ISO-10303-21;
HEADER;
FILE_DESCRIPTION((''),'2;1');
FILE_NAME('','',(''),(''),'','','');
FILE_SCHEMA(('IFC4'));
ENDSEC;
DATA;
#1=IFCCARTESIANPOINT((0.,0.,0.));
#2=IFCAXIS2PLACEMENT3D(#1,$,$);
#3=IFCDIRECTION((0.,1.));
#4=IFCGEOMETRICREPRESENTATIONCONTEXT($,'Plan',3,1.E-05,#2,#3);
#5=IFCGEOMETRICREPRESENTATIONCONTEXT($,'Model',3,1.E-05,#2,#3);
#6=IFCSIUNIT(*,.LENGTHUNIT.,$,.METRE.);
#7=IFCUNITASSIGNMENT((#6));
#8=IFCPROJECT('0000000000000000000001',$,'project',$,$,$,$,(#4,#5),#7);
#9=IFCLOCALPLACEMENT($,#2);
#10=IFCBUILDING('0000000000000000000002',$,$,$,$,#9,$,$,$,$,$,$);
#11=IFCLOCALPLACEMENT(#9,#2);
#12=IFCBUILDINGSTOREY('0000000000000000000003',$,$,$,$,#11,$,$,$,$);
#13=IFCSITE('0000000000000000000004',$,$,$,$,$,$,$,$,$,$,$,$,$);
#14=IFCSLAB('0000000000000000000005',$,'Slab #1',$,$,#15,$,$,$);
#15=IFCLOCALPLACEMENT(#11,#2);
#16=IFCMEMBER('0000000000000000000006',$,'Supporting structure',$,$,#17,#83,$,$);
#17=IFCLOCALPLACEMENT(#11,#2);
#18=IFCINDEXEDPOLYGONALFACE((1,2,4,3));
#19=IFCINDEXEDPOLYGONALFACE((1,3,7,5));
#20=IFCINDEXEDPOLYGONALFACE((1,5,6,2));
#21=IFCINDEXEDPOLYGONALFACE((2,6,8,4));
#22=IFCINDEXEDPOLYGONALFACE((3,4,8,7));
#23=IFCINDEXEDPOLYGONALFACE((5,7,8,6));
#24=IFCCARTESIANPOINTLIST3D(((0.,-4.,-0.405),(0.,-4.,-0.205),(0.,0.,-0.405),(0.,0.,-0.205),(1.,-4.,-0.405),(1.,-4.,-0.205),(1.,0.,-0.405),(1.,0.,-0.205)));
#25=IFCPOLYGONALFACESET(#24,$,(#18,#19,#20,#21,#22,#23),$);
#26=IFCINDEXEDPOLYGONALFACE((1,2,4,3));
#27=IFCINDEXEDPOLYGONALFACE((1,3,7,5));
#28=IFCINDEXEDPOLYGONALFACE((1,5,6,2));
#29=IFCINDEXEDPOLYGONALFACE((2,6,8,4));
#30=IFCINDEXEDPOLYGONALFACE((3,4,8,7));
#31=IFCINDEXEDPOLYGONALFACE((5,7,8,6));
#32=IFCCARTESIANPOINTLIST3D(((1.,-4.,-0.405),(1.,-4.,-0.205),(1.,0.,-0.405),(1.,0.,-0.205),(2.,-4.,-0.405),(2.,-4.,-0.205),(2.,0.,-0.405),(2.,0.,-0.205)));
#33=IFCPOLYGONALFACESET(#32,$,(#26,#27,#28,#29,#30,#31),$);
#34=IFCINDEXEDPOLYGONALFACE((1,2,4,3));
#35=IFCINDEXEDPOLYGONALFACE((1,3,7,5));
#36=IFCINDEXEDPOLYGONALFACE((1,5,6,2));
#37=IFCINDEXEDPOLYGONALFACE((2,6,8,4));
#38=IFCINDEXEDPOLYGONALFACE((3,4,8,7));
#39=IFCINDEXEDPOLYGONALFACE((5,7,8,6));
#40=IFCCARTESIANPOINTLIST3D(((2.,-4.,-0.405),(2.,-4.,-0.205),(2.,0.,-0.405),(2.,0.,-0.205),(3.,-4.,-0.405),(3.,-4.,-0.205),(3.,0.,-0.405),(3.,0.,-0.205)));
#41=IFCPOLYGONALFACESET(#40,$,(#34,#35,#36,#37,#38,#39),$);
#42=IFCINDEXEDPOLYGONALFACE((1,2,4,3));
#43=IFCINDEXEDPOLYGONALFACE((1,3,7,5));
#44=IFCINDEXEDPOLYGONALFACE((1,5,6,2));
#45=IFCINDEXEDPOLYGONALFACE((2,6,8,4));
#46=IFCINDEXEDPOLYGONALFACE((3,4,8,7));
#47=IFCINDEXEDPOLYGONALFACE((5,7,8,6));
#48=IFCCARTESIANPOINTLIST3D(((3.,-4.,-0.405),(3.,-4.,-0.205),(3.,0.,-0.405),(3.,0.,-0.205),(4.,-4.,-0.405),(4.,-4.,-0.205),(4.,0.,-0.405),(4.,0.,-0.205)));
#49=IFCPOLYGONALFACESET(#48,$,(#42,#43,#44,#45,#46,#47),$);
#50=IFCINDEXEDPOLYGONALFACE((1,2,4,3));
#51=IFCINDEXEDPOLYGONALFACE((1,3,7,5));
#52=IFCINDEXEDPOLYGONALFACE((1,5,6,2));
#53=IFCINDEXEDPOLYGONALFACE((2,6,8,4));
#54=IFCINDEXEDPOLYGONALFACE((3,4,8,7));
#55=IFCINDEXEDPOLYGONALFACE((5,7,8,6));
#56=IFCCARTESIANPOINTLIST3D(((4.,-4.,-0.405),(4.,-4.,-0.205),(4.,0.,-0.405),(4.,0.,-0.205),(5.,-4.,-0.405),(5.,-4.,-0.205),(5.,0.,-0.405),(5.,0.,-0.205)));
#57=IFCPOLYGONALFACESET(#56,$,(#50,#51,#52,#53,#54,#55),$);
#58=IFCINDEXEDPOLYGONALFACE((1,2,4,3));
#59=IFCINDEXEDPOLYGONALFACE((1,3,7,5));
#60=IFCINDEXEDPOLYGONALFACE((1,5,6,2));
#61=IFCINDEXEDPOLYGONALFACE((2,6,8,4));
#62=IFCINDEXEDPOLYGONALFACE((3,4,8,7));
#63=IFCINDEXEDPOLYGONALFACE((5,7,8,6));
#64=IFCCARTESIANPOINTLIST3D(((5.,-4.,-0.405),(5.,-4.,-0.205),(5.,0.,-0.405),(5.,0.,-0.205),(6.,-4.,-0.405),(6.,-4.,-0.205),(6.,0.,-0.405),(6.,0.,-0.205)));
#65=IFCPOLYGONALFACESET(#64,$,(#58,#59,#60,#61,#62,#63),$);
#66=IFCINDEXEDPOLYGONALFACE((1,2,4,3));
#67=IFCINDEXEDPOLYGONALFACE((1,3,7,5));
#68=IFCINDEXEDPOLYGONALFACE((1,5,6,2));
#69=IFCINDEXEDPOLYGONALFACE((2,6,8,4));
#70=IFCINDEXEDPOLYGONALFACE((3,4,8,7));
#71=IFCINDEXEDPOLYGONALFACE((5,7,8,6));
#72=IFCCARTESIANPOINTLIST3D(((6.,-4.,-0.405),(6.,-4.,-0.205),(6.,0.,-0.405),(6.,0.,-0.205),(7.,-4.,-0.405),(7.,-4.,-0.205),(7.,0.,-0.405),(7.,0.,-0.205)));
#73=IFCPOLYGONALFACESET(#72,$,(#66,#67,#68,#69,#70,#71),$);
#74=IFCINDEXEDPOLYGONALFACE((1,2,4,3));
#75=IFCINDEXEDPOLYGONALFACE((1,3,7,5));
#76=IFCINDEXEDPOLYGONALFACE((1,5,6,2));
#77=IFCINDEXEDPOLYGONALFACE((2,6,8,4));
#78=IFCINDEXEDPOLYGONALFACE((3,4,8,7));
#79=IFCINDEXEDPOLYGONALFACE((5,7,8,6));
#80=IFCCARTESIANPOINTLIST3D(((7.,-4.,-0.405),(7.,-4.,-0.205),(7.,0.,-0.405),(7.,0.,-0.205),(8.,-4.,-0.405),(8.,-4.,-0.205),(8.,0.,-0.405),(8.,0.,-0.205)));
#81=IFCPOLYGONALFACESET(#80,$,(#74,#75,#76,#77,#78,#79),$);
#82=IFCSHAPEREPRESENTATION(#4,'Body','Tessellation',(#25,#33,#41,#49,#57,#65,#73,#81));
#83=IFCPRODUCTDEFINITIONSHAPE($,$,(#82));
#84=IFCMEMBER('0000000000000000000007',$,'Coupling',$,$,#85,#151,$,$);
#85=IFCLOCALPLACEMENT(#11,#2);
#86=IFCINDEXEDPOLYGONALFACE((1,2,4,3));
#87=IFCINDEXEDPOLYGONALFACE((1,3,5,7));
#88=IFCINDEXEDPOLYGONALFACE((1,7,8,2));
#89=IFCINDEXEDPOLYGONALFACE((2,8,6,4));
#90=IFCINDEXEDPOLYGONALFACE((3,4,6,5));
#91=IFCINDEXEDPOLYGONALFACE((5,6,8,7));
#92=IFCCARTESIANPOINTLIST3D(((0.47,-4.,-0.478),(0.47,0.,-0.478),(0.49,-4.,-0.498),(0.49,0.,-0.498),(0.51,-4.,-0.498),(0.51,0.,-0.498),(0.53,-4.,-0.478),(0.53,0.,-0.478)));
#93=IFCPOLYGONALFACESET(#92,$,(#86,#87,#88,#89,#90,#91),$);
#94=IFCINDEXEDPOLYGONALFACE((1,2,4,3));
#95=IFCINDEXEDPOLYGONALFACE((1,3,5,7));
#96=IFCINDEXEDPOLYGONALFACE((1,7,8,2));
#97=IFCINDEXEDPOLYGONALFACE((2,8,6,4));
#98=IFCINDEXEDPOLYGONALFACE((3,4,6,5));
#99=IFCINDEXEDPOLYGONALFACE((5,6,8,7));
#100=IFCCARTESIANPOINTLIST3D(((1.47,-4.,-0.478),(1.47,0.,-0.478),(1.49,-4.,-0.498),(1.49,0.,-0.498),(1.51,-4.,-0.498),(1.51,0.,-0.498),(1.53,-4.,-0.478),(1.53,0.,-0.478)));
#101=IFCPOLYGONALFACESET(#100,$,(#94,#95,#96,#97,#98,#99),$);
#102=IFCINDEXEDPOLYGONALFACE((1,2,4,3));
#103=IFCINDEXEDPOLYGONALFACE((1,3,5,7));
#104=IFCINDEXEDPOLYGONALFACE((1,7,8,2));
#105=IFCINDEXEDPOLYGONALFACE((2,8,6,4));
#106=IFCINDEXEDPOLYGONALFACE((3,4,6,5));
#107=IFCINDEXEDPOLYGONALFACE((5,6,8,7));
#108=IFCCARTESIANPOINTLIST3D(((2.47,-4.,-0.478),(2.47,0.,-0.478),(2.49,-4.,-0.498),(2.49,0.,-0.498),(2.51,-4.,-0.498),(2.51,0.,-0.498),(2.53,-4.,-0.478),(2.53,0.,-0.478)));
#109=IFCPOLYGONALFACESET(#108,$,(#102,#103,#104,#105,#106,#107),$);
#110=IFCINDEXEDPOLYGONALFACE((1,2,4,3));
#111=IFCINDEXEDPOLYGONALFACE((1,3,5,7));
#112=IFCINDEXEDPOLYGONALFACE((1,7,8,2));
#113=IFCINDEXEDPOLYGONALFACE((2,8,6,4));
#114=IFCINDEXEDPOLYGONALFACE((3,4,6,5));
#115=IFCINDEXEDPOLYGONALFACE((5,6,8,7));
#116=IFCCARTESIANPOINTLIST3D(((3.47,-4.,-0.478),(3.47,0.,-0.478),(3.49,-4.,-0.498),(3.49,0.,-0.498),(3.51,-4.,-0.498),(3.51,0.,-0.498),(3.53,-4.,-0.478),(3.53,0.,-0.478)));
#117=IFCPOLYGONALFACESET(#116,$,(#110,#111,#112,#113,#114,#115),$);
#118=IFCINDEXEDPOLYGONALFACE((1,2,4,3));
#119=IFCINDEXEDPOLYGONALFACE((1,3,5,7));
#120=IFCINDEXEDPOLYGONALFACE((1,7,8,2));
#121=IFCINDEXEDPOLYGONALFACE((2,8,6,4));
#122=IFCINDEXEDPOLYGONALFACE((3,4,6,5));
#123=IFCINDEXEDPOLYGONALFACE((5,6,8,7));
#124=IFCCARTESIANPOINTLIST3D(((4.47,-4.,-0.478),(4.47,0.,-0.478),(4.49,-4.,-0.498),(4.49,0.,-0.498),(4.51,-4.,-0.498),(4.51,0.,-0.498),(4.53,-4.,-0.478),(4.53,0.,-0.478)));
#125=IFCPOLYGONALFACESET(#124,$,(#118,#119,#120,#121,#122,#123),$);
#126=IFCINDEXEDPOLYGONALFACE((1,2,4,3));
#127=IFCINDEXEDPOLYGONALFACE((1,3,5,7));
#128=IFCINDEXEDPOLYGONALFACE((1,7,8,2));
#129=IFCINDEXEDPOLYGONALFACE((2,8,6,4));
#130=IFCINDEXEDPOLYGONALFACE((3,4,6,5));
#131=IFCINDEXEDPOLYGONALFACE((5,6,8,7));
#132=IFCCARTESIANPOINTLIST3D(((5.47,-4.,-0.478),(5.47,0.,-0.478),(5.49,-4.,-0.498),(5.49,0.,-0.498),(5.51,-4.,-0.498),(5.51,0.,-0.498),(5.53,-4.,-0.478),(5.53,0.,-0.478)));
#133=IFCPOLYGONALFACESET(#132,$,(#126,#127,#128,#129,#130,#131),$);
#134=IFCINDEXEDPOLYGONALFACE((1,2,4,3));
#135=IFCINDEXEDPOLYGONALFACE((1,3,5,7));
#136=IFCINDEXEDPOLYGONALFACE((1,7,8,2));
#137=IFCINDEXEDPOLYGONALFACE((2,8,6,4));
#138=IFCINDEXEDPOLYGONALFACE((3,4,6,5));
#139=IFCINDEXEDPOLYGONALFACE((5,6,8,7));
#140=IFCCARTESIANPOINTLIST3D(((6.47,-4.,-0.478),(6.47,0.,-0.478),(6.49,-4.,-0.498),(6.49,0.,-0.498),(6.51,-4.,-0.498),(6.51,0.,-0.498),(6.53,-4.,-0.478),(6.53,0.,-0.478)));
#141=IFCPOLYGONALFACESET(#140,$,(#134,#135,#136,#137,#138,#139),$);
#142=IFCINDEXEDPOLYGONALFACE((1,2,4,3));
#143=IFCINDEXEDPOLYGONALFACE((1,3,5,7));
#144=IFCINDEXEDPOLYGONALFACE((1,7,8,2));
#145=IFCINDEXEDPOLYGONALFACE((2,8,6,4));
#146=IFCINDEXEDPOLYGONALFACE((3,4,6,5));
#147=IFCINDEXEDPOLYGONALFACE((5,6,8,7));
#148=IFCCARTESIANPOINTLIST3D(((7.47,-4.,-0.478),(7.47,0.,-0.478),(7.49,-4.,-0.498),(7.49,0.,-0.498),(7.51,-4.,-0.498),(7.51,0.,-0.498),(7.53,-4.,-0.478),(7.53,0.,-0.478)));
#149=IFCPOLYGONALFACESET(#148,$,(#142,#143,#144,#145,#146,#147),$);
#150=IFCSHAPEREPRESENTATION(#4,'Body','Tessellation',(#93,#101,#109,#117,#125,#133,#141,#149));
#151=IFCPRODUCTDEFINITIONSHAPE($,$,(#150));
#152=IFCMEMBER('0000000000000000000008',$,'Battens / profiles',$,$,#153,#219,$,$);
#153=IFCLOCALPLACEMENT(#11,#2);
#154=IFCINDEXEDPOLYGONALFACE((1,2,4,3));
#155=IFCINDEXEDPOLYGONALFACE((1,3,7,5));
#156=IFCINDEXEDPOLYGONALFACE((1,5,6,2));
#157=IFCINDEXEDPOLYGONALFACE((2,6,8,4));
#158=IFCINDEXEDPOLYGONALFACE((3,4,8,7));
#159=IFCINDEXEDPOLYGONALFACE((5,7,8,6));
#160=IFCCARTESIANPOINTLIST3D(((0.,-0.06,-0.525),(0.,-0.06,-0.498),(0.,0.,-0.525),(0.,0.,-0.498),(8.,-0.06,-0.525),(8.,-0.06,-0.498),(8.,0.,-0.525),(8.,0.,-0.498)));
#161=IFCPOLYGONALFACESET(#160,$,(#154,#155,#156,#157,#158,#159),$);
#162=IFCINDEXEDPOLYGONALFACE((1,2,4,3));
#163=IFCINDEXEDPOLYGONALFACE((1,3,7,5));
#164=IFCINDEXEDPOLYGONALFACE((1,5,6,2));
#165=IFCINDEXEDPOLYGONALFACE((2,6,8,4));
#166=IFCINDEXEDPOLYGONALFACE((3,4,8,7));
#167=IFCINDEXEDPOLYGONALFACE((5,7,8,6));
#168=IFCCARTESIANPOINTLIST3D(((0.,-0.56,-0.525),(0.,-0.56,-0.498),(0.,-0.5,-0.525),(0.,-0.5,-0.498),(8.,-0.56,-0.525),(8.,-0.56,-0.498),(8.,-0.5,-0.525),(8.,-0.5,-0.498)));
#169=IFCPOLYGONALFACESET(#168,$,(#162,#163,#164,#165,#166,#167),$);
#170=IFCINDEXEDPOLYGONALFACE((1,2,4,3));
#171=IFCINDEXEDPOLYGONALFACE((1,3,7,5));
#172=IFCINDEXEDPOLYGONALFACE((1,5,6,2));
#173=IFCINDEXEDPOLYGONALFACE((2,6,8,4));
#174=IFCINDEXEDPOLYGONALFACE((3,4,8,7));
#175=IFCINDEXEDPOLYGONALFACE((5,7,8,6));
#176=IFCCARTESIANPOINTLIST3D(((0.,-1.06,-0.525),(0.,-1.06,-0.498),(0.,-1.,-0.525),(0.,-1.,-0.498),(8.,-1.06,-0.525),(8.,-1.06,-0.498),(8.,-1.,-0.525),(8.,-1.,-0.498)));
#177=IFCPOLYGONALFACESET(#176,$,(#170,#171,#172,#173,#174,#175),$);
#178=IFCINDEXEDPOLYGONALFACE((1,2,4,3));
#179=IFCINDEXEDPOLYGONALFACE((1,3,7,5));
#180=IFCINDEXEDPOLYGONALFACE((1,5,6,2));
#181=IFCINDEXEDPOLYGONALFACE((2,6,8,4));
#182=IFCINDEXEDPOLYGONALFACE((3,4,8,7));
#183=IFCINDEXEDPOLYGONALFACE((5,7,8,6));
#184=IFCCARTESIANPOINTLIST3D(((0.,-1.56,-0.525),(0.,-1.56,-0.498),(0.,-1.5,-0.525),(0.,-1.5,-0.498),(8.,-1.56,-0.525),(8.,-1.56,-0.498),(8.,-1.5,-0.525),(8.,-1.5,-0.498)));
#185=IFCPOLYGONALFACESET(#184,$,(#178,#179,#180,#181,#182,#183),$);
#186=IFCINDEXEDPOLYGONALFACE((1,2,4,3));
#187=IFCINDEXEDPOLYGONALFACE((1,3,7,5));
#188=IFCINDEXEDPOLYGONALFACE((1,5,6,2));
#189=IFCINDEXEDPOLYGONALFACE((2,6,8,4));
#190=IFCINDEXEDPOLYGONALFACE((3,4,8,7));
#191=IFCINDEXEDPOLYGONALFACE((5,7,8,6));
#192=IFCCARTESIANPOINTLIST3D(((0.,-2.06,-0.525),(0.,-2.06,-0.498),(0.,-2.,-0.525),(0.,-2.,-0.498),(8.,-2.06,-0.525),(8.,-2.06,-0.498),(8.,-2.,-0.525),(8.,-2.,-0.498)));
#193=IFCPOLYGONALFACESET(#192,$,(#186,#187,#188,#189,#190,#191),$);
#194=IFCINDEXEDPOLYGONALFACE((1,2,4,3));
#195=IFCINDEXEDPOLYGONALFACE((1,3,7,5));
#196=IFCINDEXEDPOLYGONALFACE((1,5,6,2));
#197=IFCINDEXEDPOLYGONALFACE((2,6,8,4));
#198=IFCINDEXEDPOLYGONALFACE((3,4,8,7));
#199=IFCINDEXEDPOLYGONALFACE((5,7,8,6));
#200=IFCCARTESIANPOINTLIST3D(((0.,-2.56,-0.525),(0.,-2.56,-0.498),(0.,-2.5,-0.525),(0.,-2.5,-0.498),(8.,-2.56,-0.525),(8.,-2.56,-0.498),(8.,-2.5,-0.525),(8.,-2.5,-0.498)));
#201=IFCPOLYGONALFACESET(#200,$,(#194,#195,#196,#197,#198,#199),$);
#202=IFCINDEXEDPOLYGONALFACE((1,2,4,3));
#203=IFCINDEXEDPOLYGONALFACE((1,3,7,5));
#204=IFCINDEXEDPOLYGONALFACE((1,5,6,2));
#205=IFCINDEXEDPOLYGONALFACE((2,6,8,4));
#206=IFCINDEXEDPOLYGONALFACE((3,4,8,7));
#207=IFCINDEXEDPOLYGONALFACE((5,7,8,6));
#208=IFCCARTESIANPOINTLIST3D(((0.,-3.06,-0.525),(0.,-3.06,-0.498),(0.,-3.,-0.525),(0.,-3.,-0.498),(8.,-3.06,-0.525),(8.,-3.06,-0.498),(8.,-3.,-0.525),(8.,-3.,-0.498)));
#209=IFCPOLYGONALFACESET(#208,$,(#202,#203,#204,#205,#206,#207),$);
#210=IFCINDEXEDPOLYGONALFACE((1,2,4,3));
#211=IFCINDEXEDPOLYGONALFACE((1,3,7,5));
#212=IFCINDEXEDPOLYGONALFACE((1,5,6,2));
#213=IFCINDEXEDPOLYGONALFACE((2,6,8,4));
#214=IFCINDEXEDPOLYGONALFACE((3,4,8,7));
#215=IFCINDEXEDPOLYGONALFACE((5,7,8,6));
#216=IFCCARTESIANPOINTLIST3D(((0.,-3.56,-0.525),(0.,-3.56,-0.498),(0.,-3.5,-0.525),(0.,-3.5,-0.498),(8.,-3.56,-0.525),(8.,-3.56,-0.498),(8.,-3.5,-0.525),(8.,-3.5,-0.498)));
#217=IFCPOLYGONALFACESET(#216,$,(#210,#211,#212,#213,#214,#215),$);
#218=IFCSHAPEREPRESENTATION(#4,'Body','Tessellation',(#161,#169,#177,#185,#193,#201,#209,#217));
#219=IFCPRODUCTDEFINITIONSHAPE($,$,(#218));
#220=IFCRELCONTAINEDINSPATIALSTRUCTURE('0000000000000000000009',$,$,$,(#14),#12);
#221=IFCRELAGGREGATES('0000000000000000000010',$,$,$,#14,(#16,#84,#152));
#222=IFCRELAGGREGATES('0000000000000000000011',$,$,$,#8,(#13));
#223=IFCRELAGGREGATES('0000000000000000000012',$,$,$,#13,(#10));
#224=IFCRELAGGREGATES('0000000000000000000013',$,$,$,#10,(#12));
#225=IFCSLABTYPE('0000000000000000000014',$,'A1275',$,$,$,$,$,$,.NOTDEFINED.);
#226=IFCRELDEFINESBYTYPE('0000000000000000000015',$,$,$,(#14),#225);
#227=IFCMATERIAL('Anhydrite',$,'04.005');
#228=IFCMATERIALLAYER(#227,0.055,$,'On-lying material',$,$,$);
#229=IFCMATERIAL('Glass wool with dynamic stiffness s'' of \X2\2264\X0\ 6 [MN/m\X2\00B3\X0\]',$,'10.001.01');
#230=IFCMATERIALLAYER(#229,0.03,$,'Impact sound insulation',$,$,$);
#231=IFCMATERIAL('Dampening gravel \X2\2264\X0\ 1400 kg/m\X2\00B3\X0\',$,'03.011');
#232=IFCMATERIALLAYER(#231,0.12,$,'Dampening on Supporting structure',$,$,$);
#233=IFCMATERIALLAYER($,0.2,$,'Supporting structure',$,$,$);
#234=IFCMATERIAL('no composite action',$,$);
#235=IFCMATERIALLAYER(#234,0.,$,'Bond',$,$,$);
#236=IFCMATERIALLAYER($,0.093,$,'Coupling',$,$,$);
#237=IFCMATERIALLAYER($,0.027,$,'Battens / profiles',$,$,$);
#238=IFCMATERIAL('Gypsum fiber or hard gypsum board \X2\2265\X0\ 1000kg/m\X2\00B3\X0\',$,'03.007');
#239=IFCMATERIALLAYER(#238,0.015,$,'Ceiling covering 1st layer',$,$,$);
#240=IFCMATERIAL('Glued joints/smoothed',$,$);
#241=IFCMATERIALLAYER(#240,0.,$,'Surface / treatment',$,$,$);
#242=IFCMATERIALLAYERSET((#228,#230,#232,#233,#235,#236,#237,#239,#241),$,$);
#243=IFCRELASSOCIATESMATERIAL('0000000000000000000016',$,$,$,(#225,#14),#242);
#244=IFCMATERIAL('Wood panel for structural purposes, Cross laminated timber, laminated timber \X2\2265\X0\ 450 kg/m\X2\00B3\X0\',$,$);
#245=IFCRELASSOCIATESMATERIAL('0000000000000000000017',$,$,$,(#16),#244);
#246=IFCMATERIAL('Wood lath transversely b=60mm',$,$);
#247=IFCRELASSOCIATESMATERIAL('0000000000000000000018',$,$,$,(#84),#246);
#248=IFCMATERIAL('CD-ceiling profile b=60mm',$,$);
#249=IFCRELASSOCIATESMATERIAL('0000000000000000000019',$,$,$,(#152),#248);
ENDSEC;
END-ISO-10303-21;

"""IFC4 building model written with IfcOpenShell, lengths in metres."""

from ifc_helpers import new_model, si_unit, direction, frame, frame_2d, origin, place, context, project, spatial, polyline, rectangle, outline, extrude, material, layer, layer_set, type_object, element, aggregate, save


model = new_model("IFC4")

# Units and contexts
plan_context = context("Plan", 3, precision=1e-05, world=origin(), true_north=direction((0.0, 1.0)))
model_context = context("Model", 3, precision=1e-05, world=origin(), true_north=direction((0.0, 1.0)))
ifc_project = project(units=[si_unit("LENGTHUNIT", "METRE")], contexts=[plan_context, model_context])

# Site, building, storey
site = spatial("IfcSite", under=ifc_project)
building_placement = place(None, origin())
building = spatial("IfcBuilding", under=site, at=building_placement)
storey_placement = place(building_placement, origin())
storey = spatial("IfcBuildingStorey", under=building, at=storey_placement)

# Slab, members
ifc_material_1 = material(Name="Anhydrite", Category="04.005")
ifc_layer_1 = layer(ifc_material_1, 0.055, Name="On-lying material")
ifc_material_2 = material(Name="Glass wool with dynamic stiffness s' of ≤ 6 [MN/m³]", Category="10.001.01")
ifc_layer_2 = layer(ifc_material_2, 0.03, Name="Impact sound insulation")
ifc_material_3 = material(Name="Dampening gravel ≤ 1400 kg/m³", Category="03.011")
ifc_layer_3 = layer(ifc_material_3, 0.12, Name="Dampening on Supporting structure")
ifc_layer_4 = layer(None, 0.2, Name="Supporting structure")
ifc_material_4 = material(Name="no composite action")
ifc_layer_5 = layer(ifc_material_4, 0.0, Name="Bond")
ifc_layer_6 = layer(None, 0.093, Name="Coupling")
ifc_layer_7 = layer(None, 0.027, Name="Battens / profiles")
ifc_material_5 = material(Name="Gypsum fiber or hard gypsum board ≥ 1000kg/m³", Category="03.007")
ifc_layer_8 = layer(ifc_material_5, 0.015, Name="Ceiling covering 1st layer")
ifc_material_6 = material(Name="Glued joints/smoothed")
ifc_layer_9 = layer(ifc_material_6, 0.0, Name="Surface / treatment")
ifc_layer_set = layer_set([ifc_layer_1, ifc_layer_2, ifc_layer_3, ifc_layer_4, ifc_layer_5, ifc_layer_6, ifc_layer_7, ifc_layer_8, ifc_layer_9])
slab_type = type_object("IfcSlabType", Name="A1275", PredefinedType="NOTDEFINED", material=ifc_layer_set)
slab_placement = place(None, frame((0.0, 0.0, 0.0), z_axis=(0.0, 0.0, -1.0), x_axis=(1.0, 0.0, 0.0)))
slab = element("IfcSlab", 1, at=slab_placement, inside=storey, type_object=slab_type, material=ifc_layer_set, Name="Slab #1")
ifc_material_7 = material(Name="Wood panel for structural purposes, Cross laminated timber, laminated timber ≥ 450 kg/m³")
member_1_placement = place(slab_placement, origin())
member_1 = element("IfcMember", 2, at=member_1_placement, material=ifc_material_7, Name="Supporting structure", context=plan_context, shape_type="SweptSolid", body=[
    extrude(rectangle(XDim=1.0, YDim=0.2, at=frame_2d((0.5, 0.1), x_axis=(1.0, 0.0))), frame((0.0, 4.0, 0.205), z_axis=(0.0, -1.0, 0.0), x_axis=(1.0, 0.0, 0.0)), (0.0, 0.0, 1.0), 4.0),
    extrude(rectangle(XDim=1.0, YDim=0.2, at=frame_2d((0.5, 0.1), x_axis=(1.0, 0.0))), frame((1.0, 4.0, 0.205), z_axis=(0.0, -1.0, 0.0), x_axis=(1.0, 0.0, 0.0)), (0.0, 0.0, 1.0), 4.0),
    extrude(rectangle(XDim=1.0, YDim=0.2, at=frame_2d((0.5, 0.1), x_axis=(1.0, 0.0))), frame((2.0, 4.0, 0.205), z_axis=(0.0, -1.0, 0.0), x_axis=(1.0, 0.0, 0.0)), (0.0, 0.0, 1.0), 4.0),
    extrude(rectangle(XDim=1.0, YDim=0.2, at=frame_2d((0.5, 0.1), x_axis=(1.0, 0.0))), frame((3.0, 4.0, 0.205), z_axis=(0.0, -1.0, 0.0), x_axis=(1.0, 0.0, 0.0)), (0.0, 0.0, 1.0), 4.0),
    extrude(rectangle(XDim=1.0, YDim=0.2, at=frame_2d((0.5, 0.1), x_axis=(1.0, 0.0))), frame((4.0, 4.0, 0.205), z_axis=(0.0, -1.0, 0.0), x_axis=(1.0, 0.0, 0.0)), (0.0, 0.0, 1.0), 4.0),
    extrude(rectangle(XDim=1.0, YDim=0.2, at=frame_2d((0.5, 0.1), x_axis=(1.0, 0.0))), frame((5.0, 4.0, 0.205), z_axis=(0.0, -1.0, 0.0), x_axis=(1.0, 0.0, 0.0)), (0.0, 0.0, 1.0), 4.0),
    extrude(rectangle(XDim=1.0, YDim=0.2, at=frame_2d((0.5, 0.1), x_axis=(1.0, 0.0))), frame((6.0, 4.0, 0.205), z_axis=(0.0, -1.0, 0.0), x_axis=(1.0, 0.0, 0.0)), (0.0, 0.0, 1.0), 4.0),
    extrude(rectangle(XDim=1.0, YDim=0.2, at=frame_2d((0.5, 0.1), x_axis=(1.0, 0.0))), frame((7.0, 4.0, 0.205), z_axis=(0.0, -1.0, 0.0), x_axis=(1.0, 0.0, 0.0)), (0.0, 0.0, 1.0), 4.0),
])
ifc_material_8 = material(Name="Wood lath transversely b=60mm")
member_2_placement = place(slab_placement, origin())
member_2 = element("IfcMember", 3, at=member_2_placement, material=ifc_material_8, Name="Coupling", context=plan_context, shape_type="SweptSolid", body=[
    extrude(outline(polyline([(0.0, 0.0), (0.06, 0.0), (0.04, 0.02), (0.02, 0.02), (0.0, 0.0)])), frame((0.47, 4.0, 0.478), z_axis=(0.0, -1.0, 0.0), x_axis=(1.0, 0.0, 0.0)), (0.0, 0.0, 1.0), 4.0),
    extrude(outline(polyline([(0.0, 0.0), (0.06, 0.0), (0.04, 0.02), (0.02, 0.02), (0.0, 0.0)])), frame((1.47, 4.0, 0.478), z_axis=(0.0, -1.0, 0.0), x_axis=(1.0, 0.0, 0.0)), (0.0, 0.0, 1.0), 4.0),
    extrude(outline(polyline([(0.0, 0.0), (0.06, 0.0), (0.04, 0.02), (0.02, 0.02), (0.0, 0.0)])), frame((2.47, 4.0, 0.478), z_axis=(0.0, -1.0, 0.0), x_axis=(1.0, 0.0, 0.0)), (0.0, 0.0, 1.0), 4.0),
    extrude(outline(polyline([(0.0, 0.0), (0.06, 0.0), (0.04, 0.02), (0.02, 0.02), (0.0, 0.0)])), frame((3.47, 4.0, 0.478), z_axis=(0.0, -1.0, 0.0), x_axis=(1.0, 0.0, 0.0)), (0.0, 0.0, 1.0), 4.0),
    extrude(outline(polyline([(0.0, 0.0), (0.06, 0.0), (0.04, 0.02), (0.02, 0.02), (0.0, 0.0)])), frame((4.47, 4.0, 0.478), z_axis=(0.0, -1.0, 0.0), x_axis=(1.0, 0.0, 0.0)), (0.0, 0.0, 1.0), 4.0),
    extrude(outline(polyline([(0.0, 0.0), (0.06, 0.0), (0.04, 0.02), (0.02, 0.02), (0.0, 0.0)])), frame((5.47, 4.0, 0.478), z_axis=(0.0, -1.0, 0.0), x_axis=(1.0, 0.0, 0.0)), (0.0, 0.0, 1.0), 4.0),
    extrude(outline(polyline([(0.0, 0.0), (0.06, 0.0), (0.04, 0.02), (0.02, 0.02), (0.0, 0.0)])), frame((6.47, 4.0, 0.478), z_axis=(0.0, -1.0, 0.0), x_axis=(1.0, 0.0, 0.0)), (0.0, 0.0, 1.0), 4.0),
    extrude(outline(polyline([(0.0, 0.0), (0.06, 0.0), (0.04, 0.02), (0.02, 0.02), (0.0, 0.0)])), frame((7.47, 4.0, 0.478), z_axis=(0.0, -1.0, 0.0), x_axis=(1.0, 0.0, 0.0)), (0.0, 0.0, 1.0), 4.0),
])
ifc_material_9 = material(Name="CD-ceiling profile b=60mm")
member_3_placement = place(slab_placement, origin())
member_3 = element("IfcMember", 4, at=member_3_placement, material=ifc_material_9, Name="Battens / profiles", context=plan_context, shape_type="SweptSolid", body=[
    extrude(rectangle(XDim=0.06, YDim=0.027, at=frame_2d((0.03, 0.0135), x_axis=(1.0, 0.0))), frame((0.0, 0.0, 0.498), z_axis=(1.0, 0.0, 0.0), x_axis=(0.0, 1.0, 0.0)), (0.0, 0.0, 1.0), 8.0),
    extrude(rectangle(XDim=0.06, YDim=0.027, at=frame_2d((0.03, 0.0135), x_axis=(1.0, 0.0))), frame((0.0, 0.5, 0.498), z_axis=(1.0, 0.0, 0.0), x_axis=(0.0, 1.0, 0.0)), (0.0, 0.0, 1.0), 8.0),
    extrude(rectangle(XDim=0.06, YDim=0.027, at=frame_2d((0.03, 0.0135), x_axis=(1.0, 0.0))), frame((0.0, 1.0, 0.498), z_axis=(1.0, 0.0, 0.0), x_axis=(0.0, 1.0, 0.0)), (0.0, 0.0, 1.0), 8.0),
    extrude(rectangle(XDim=0.06, YDim=0.027, at=frame_2d((0.03, 0.0135), x_axis=(1.0, 0.0))), frame((0.0, 1.5, 0.498), z_axis=(1.0, 0.0, 0.0), x_axis=(0.0, 1.0, 0.0)), (0.0, 0.0, 1.0), 8.0),
    extrude(rectangle(XDim=0.06, YDim=0.027, at=frame_2d((0.03, 0.0135), x_axis=(1.0, 0.0))), frame((0.0, 2.0, 0.498), z_axis=(1.0, 0.0, 0.0), x_axis=(0.0, 1.0, 0.0)), (0.0, 0.0, 1.0), 8.0),
    extrude(rectangle(XDim=0.06, YDim=0.027, at=frame_2d((0.03, 0.0135), x_axis=(1.0, 0.0))), frame((0.0, 2.5, 0.498), z_axis=(1.0, 0.0, 0.0), x_axis=(0.0, 1.0, 0.0)), (0.0, 0.0, 1.0), 8.0),
    extrude(rectangle(XDim=0.06, YDim=0.027, at=frame_2d((0.03, 0.0135), x_axis=(1.0, 0.0))), frame((0.0, 3.0, 0.498), z_axis=(1.0, 0.0, 0.0), x_axis=(0.0, 1.0, 0.0)), (0.0, 0.0, 1.0), 8.0),
    extrude(rectangle(XDim=0.06, YDim=0.027, at=frame_2d((0.03, 0.0135), x_axis=(1.0, 0.0))), frame((0.0, 3.5, 0.498), z_axis=(1.0, 0.0, 0.0), x_axis=(0.0, 1.0, 0.0)), (0.0, 0.0, 1.0), 8.0),
])
aggregate(slab, [member_1, member_2, member_3])

save(model, "model.ifc")
